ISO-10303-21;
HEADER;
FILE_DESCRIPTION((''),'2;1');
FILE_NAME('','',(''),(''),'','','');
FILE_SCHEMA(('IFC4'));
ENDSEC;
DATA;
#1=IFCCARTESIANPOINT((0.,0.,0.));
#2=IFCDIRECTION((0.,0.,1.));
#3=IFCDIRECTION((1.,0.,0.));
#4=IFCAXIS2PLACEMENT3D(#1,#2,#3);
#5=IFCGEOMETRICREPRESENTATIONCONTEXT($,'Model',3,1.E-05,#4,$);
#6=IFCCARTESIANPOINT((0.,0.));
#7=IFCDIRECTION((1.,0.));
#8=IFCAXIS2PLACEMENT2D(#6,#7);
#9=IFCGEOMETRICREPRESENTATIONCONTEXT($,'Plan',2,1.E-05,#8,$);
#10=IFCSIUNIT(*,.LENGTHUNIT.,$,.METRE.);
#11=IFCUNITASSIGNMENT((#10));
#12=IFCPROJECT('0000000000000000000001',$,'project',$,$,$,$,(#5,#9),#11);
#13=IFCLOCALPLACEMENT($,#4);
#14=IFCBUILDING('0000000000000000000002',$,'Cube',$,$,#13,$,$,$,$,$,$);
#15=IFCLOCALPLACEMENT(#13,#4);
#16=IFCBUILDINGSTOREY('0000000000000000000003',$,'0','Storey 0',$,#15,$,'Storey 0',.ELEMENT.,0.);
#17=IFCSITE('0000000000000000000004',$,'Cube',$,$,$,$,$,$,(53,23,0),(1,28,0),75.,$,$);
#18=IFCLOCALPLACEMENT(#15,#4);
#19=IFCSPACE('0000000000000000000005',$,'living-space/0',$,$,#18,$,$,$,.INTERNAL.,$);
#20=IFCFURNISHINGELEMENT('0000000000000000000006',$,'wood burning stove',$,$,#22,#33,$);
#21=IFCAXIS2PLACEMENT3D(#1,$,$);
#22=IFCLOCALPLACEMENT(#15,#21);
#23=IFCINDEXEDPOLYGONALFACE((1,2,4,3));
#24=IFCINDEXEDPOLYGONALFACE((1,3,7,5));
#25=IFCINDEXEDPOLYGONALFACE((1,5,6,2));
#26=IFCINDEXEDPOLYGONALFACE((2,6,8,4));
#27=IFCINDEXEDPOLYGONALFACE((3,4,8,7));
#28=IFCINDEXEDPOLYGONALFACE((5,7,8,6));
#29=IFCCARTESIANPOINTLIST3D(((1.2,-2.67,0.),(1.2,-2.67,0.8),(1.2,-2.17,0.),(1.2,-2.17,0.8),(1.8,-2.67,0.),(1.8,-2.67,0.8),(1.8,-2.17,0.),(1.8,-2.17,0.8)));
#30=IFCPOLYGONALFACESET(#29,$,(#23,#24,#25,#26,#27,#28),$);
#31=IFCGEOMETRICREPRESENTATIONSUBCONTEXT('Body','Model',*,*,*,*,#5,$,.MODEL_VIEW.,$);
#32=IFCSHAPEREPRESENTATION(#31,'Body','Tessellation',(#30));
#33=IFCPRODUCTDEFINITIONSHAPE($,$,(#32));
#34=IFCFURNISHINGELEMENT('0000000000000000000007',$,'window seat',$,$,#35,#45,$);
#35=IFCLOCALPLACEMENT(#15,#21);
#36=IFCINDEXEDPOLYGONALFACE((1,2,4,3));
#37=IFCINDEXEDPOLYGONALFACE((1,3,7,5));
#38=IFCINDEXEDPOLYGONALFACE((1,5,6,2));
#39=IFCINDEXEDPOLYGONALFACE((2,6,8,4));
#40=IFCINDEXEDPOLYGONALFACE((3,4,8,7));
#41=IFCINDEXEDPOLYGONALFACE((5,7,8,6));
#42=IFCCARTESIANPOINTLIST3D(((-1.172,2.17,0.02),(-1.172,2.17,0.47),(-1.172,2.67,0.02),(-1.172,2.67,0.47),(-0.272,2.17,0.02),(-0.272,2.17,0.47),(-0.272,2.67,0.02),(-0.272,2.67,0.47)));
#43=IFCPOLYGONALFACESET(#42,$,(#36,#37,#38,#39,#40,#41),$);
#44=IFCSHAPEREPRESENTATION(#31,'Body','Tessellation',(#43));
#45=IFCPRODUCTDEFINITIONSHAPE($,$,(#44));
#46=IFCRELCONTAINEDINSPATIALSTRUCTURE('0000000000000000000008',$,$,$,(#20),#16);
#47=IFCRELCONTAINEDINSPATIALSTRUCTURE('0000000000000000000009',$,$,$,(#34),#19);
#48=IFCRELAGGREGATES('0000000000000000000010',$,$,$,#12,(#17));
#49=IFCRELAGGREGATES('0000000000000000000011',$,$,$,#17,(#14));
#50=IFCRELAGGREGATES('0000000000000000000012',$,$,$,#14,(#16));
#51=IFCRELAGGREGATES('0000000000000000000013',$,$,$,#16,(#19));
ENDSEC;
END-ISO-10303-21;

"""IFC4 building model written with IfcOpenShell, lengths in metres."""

from ifc_helpers import new_model, si_unit, frame, origin_with_axes, origin_2d_with_axis, place, context, subcontext, project, spatial, indexed_curve, outline, extrude, element, save


model = new_model("IFC4")

# Units and contexts
model_context = context("Model", 3, precision=1e-05, world=origin_with_axes())
plan_context = context("Plan", 2, precision=1e-05, world=origin_2d_with_axis())
body_context_1 = subcontext(model_context, "Body", "Model", "MODEL_VIEW")
ifc_project = project(units=[si_unit("LENGTHUNIT", "METRE")], contexts=[model_context, plan_context])

# Site, building, storey
site = spatial("IfcSite", under=ifc_project, Name="Cube", RefLatitude=(53, 23, 0), RefLongitude=(1, 28, 0), RefElevation=75.0)
building_placement = place(None, origin_with_axes())
building = spatial("IfcBuilding", under=site, at=building_placement, Name="Cube")
storey_placement = place(building_placement, origin_with_axes())
storey = spatial("IfcBuildingStorey", under=building, at=storey_placement, Name="0", Description="Storey 0", LongName="Storey 0", CompositionType="ELEMENT", Elevation=0.0)

# Shared definitions
space_placement = place(storey_placement, origin_with_axes())
space = spatial("IfcSpace", under=storey, at=space_placement, Name="living-space/0", PredefinedType="INTERNAL")

# Furnishing elements
furnishing_1_placement = place(storey_placement, frame((1.2, -2.67, 0.0), z_axis=(0.0, 0.0, 1.0), x_axis=(1.0, 0.0, 0.0)))
element("IfcFurnishingElement", 1, at=furnishing_1_placement, inside=storey, Name="wood burning stove", context=body_context_1, shape_type="SweptSolid", body=[
    extrude(outline(indexed_curve([(0.0, 0.0), (0.6, 0.0), (0.6, 0.5), (0.0, 0.5)])), None, (0.0, 0.0, 1.0), 0.8),
])
furnishing_2_placement = place(space_placement, frame((-1.172, 2.17, 0.02), z_axis=(0.0, 0.0, 1.0), x_axis=(1.0, 0.0, 0.0)))
element("IfcFurnishingElement", 2, at=furnishing_2_placement, inside=space, Name="window seat", context=body_context_1, shape_type="SweptSolid", body=[
    extrude(outline(indexed_curve([(0.0, 0.0), (0.9, 0.0), (0.9, 0.5), (0.0, 0.5)])), None, (0.0, 0.0, 1.0), 0.45),
])

save(model, "model.ifc")
